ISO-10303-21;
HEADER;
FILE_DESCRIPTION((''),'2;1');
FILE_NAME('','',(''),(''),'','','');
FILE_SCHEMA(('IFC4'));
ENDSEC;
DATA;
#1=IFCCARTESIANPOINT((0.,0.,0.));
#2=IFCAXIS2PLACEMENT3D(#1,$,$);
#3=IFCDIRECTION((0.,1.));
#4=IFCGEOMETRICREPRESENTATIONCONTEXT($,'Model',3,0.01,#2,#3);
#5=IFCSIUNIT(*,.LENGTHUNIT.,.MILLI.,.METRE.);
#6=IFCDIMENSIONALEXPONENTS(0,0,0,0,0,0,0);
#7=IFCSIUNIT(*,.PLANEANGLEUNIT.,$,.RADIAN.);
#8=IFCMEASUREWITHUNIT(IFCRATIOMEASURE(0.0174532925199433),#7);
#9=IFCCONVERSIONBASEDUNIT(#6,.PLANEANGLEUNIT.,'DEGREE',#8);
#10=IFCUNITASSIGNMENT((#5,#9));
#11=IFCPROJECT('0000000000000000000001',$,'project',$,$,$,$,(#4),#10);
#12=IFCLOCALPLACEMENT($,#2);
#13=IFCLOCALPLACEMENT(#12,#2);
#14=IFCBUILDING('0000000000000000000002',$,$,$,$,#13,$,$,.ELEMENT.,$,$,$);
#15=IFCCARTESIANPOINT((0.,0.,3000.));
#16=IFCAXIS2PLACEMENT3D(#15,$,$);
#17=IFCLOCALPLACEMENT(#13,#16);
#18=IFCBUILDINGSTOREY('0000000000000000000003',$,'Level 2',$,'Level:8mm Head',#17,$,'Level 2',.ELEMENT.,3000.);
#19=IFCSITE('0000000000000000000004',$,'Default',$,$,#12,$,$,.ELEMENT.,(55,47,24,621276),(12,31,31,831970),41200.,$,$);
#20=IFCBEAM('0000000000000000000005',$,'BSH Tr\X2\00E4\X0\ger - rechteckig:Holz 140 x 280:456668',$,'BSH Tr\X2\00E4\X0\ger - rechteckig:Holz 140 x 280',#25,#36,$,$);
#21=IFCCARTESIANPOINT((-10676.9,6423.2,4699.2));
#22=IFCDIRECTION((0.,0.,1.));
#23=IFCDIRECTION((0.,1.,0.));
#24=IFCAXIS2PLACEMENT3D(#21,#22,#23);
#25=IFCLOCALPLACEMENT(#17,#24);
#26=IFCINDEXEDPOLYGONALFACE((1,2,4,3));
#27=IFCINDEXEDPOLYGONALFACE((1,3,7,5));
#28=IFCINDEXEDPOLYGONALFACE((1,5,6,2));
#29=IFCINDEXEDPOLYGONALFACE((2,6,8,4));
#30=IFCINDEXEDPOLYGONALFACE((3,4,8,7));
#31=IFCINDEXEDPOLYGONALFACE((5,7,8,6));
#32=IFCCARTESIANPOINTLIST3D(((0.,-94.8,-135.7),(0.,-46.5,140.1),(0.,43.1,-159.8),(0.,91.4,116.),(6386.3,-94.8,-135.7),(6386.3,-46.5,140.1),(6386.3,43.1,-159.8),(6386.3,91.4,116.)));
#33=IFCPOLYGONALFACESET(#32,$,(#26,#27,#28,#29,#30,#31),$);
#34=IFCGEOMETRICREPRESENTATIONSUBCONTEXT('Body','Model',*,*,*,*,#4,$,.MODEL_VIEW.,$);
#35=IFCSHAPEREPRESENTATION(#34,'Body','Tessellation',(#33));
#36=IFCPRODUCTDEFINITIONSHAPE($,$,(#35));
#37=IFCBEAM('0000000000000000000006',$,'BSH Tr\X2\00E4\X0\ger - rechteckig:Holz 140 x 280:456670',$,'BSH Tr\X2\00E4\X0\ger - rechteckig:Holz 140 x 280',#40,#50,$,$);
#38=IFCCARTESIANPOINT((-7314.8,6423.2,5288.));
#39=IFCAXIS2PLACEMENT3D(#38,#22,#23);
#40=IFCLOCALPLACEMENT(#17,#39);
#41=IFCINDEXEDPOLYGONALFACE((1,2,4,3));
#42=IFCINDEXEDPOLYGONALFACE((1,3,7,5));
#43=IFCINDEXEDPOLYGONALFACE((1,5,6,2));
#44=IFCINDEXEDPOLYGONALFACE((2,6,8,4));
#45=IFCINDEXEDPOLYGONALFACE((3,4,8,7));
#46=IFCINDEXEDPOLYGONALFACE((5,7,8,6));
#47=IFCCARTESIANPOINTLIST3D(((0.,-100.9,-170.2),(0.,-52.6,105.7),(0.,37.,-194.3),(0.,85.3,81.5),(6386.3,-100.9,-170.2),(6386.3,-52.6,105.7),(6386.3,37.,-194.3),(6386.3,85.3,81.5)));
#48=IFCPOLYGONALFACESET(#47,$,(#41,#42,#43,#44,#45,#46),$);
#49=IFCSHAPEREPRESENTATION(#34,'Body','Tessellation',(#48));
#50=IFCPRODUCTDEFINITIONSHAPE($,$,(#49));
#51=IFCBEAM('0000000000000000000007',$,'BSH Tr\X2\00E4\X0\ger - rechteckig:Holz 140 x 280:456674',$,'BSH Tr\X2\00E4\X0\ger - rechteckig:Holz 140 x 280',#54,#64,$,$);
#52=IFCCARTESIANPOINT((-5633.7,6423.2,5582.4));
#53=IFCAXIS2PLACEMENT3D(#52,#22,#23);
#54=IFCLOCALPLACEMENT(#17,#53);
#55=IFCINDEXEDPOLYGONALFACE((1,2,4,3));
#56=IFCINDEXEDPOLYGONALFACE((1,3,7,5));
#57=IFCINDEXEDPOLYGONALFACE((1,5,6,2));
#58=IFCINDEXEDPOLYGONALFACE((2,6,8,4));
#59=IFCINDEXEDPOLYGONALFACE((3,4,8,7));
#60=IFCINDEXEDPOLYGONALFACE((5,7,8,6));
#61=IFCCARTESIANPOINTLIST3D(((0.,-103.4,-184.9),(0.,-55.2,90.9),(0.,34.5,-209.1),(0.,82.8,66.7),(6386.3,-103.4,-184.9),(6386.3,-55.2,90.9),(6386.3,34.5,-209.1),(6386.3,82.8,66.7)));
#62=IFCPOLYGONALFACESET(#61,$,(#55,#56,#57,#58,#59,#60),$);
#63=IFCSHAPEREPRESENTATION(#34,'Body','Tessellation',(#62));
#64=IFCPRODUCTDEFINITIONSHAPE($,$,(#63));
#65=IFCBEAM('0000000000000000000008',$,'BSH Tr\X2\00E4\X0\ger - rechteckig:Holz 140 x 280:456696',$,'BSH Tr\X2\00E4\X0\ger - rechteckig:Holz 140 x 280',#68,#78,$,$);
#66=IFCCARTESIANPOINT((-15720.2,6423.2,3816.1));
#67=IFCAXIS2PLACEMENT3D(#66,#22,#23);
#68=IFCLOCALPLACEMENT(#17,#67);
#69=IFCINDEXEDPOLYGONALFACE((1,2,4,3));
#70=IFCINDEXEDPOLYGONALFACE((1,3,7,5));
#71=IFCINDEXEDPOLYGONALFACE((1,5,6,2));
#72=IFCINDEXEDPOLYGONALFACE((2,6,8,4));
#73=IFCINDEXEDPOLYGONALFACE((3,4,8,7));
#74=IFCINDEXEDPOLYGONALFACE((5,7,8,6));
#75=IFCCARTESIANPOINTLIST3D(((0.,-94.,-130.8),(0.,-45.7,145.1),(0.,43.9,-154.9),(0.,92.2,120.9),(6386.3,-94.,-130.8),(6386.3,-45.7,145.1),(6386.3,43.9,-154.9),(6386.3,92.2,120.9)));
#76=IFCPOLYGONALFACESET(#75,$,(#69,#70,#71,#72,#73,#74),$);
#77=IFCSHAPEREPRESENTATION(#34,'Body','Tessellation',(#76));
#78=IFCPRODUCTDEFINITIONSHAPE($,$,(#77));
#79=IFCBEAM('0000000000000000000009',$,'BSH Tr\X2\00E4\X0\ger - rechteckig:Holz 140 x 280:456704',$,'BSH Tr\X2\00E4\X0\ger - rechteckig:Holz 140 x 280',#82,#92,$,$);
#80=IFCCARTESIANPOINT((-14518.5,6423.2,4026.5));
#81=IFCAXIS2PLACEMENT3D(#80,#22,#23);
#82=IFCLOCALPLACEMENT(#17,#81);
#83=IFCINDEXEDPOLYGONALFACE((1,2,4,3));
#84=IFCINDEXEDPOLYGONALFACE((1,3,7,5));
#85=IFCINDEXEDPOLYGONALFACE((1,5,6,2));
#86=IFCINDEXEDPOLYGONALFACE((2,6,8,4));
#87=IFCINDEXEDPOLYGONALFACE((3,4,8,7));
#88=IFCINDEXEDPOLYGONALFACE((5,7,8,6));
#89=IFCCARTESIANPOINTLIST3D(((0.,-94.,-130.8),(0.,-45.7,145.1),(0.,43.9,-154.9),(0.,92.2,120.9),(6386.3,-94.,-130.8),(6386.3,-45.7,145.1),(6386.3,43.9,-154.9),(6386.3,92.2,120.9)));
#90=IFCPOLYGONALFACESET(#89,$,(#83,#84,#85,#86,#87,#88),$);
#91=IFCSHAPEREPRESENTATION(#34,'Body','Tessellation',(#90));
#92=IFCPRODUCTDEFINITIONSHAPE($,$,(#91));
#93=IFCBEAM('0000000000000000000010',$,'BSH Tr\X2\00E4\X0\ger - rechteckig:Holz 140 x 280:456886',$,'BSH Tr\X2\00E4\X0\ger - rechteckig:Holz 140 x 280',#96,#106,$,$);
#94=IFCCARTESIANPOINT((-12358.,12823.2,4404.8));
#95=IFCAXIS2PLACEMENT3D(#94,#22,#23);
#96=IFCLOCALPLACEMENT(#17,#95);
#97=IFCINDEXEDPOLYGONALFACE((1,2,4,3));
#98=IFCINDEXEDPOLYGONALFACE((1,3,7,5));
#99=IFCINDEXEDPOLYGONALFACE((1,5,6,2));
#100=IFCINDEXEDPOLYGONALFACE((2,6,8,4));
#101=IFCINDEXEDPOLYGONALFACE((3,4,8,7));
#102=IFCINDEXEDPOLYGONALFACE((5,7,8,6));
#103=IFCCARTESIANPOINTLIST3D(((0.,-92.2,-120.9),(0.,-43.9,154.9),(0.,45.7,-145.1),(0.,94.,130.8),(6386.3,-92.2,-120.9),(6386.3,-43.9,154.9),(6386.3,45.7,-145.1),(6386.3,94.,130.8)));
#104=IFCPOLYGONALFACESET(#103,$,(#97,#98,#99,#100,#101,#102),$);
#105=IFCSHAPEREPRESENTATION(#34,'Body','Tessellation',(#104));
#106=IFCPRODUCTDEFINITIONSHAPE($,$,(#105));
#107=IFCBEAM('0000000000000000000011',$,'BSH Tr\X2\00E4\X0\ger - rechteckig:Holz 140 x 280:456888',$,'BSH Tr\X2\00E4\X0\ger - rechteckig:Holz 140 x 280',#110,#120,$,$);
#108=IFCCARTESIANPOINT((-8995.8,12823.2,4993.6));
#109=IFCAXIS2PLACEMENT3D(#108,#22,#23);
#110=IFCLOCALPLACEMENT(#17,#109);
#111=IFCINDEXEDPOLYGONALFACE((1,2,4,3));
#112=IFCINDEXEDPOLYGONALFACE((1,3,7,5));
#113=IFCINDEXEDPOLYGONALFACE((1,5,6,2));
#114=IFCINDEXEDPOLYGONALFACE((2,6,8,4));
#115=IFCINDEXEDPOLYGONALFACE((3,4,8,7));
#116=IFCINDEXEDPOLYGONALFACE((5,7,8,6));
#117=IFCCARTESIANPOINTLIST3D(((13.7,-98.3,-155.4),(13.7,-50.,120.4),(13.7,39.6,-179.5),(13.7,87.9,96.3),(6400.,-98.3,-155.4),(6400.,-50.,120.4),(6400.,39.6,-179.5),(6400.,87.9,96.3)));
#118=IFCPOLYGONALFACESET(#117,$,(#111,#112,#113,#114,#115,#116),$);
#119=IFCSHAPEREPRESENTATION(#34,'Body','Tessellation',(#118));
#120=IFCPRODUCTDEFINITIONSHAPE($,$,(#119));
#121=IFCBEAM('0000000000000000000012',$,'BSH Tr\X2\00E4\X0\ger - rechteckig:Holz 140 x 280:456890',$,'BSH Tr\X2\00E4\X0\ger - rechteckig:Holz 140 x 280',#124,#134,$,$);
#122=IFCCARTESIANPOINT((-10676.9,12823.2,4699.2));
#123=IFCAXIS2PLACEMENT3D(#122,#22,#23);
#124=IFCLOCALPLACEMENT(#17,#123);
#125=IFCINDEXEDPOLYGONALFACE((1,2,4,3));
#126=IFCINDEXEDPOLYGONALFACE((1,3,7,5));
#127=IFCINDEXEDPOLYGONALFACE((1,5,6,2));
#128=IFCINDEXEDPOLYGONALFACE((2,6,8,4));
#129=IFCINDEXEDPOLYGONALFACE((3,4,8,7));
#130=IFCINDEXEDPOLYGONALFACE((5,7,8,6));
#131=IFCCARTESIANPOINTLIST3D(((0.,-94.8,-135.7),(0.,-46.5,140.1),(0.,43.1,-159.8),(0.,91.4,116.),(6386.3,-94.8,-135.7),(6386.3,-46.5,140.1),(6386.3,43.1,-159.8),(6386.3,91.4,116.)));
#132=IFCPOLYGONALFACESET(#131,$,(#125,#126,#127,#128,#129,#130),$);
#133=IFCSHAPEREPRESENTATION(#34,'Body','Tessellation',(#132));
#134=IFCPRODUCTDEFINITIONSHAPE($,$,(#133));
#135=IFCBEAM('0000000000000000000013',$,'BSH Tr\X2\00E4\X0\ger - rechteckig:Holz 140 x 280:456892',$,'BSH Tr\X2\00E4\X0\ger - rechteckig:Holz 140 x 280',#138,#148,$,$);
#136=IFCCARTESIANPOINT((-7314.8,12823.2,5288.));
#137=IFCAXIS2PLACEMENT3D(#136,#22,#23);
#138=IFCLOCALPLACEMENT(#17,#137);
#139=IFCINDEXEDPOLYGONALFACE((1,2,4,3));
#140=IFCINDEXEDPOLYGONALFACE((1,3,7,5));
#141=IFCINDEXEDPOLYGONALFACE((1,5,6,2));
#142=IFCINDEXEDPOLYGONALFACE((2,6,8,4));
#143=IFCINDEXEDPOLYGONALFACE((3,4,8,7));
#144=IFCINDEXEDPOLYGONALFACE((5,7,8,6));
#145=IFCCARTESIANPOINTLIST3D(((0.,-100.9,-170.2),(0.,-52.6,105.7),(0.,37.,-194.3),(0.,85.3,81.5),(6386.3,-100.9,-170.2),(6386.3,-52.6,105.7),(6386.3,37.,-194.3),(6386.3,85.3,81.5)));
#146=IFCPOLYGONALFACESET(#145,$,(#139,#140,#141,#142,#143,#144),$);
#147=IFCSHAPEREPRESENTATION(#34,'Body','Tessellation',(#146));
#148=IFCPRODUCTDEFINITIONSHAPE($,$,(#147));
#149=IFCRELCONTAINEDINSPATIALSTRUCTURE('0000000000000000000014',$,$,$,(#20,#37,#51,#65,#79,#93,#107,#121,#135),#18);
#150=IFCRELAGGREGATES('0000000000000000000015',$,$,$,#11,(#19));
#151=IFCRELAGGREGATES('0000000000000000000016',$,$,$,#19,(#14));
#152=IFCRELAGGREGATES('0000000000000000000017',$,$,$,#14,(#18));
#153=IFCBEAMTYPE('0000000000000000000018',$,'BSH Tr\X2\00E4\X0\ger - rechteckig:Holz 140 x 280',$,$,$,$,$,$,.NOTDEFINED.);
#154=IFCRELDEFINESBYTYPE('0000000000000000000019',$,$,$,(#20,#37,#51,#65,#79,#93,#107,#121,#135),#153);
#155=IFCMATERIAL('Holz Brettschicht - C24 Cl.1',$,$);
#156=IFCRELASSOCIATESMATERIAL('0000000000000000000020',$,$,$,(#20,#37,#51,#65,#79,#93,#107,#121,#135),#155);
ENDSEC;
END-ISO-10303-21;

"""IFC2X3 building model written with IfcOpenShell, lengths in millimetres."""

from ifc_helpers import new_model, entity, si_unit, converted_unit, direction, frame, frame_2d, origin, origin_2d_with_axis, place, context, subcontext, project, spatial, rectangle, extrude, material, type_object, element, save


model = new_model("IFC2X3")

# Units and contexts
model_context = context("Model", 3, precision=0.01, world=origin(), true_north=direction((0.0, 1.0)))
body_context = subcontext(model_context, "Body", "Model", "MODEL_VIEW")
ifc_project = project(units=[si_unit("LENGTHUNIT", "METRE", prefix="MILLI"), converted_unit("PLANEANGLEUNIT", "DEGREE", entity("IfcRatioMeasure", 0.0174532925199433), si_unit("PLANEANGLEUNIT", "RADIAN"), dimensions=[0, 0, 0, 0, 0, 0, 0])], contexts=[model_context])

# Site, building, storey
site_placement = place(None, origin())
site = spatial("IfcSite", under=ifc_project, at=site_placement, Name="Default", CompositionType="ELEMENT", RefLatitude=(55, 47, 24, 621276), RefLongitude=(12, 31, 31, 831970), RefElevation=41200.0)
building_placement = place(site_placement, origin())
building = spatial("IfcBuilding", under=site, at=building_placement, CompositionType="ELEMENT")
storey_placement = place(building_placement, frame((0.0, 0.0, 3000.0)))
storey = spatial("IfcBuildingStorey", under=building, at=storey_placement, Name="Level 2", ObjectType="Level:8mm Head", LongName="Level 2", CompositionType="ELEMENT", Elevation=3000.0)

# Shared definitions
ifc_material_1 = material(Name="Holz Brettschicht - C24 Cl.1")

# Beams
beam_type_1 = type_object("IfcBeamType", Name="BSH Träger - rechteckig:Holz 140 x 280", PredefinedType="NOTDEFINED")
beam_1_placement = place(storey_placement, frame((-10676.9, 6423.2, 4699.2), z_axis=(0.0, 0.0, 1.0), x_axis=(0.0, 1.0, 0.0)))
element("IfcBeam", 1, at=beam_1_placement, inside=storey, type_object=beam_type_1, material=ifc_material_1, Name="BSH Träger - rechteckig:Holz 140 x 280:456668", ObjectType="BSH Träger - rechteckig:Holz 140 x 280", context=body_context, shape_type="SweptSolid", body=[
    extrude(rectangle(XDim=280.0, YDim=140.0, at=origin_2d_with_axis()), frame((0.0, -1.7, -9.9), z_axis=(1.0, 0.0, 0.0), x_axis=(0.0, 0.172491, 0.985011)), (0.0, 0.0, 1.0), 6386.3),
])
beam_2_placement = place(storey_placement, frame((-7314.8, 6423.2, 5288.0), z_axis=(0.0, 0.0, 1.0), x_axis=(0.0, 1.0, 0.0)))
element("IfcBeam", 2, at=beam_2_placement, inside=storey, type_object=beam_type_1, material=ifc_material_1, Name="BSH Träger - rechteckig:Holz 140 x 280:456670", ObjectType="BSH Träger - rechteckig:Holz 140 x 280", context=body_context, shape_type="SweptSolid", body=[
    extrude(rectangle(XDim=280.0, YDim=140.0, at=origin_2d_with_axis()), frame((0.0, -7.8, -44.3), z_axis=(1.0, 0.0, 0.0), x_axis=(0.0, 0.172491, 0.985011)), (0.0, 0.0, 1.0), 6386.3),
])
beam_3_placement = place(storey_placement, frame((-5633.7, 6423.2, 5582.4), z_axis=(0.0, 0.0, 1.0), x_axis=(0.0, 1.0, 0.0)))
element("IfcBeam", 3, at=beam_3_placement, inside=storey, type_object=beam_type_1, material=ifc_material_1, Name="BSH Träger - rechteckig:Holz 140 x 280:456674", ObjectType="BSH Träger - rechteckig:Holz 140 x 280", context=body_context, shape_type="SweptSolid", body=[
    extrude(rectangle(XDim=280.0, YDim=140.0, at=origin_2d_with_axis()), frame((0.0, -10.3, -59.1), z_axis=(1.0, 0.0, 0.0), x_axis=(0.0, 0.172491, 0.985011)), (0.0, 0.0, 1.0), 6386.3),
])
beam_4_placement = place(storey_placement, frame((-15720.2, 6423.2, 3816.1), z_axis=(0.0, 0.0, 1.0), x_axis=(0.0, 1.0, 0.0)))
element("IfcBeam", 4, at=beam_4_placement, inside=storey, type_object=beam_type_1, material=ifc_material_1, Name="BSH Träger - rechteckig:Holz 140 x 280:456696", ObjectType="BSH Träger - rechteckig:Holz 140 x 280", context=body_context, shape_type="SweptSolid", body=[
    extrude(rectangle(XDim=280.0, YDim=140.0, at=origin_2d_with_axis()), frame((0.0, -0.9, -4.9), z_axis=(1.0, 0.0, 0.0), x_axis=(0.0, 0.172491, 0.985011)), (0.0, 0.0, 1.0), 6386.3),
])
beam_5_placement = place(storey_placement, frame((-14518.5, 6423.2, 4026.5), z_axis=(0.0, 0.0, 1.0), x_axis=(0.0, 1.0, 0.0)))
element("IfcBeam", 5, at=beam_5_placement, inside=storey, type_object=beam_type_1, material=ifc_material_1, Name="BSH Träger - rechteckig:Holz 140 x 280:456704", ObjectType="BSH Träger - rechteckig:Holz 140 x 280", context=body_context, shape_type="SweptSolid", body=[
    extrude(rectangle(XDim=280.0, YDim=140.0, at=frame_2d((0.0, 0.0), x_axis=(1.0, 0.0))), frame((0.0, -0.9, -4.9), z_axis=(1.0, 0.0, 0.0), x_axis=(0.0, 0.172491, 0.985011)), (0.0, 0.0, 1.0), 6386.3),
])
beam_6_placement = place(storey_placement, frame((-12358.0, 12823.2, 4404.8), z_axis=(0.0, 0.0, 1.0), x_axis=(0.0, 1.0, 0.0)))
element("IfcBeam", 6, at=beam_6_placement, inside=storey, type_object=beam_type_1, material=ifc_material_1, Name="BSH Träger - rechteckig:Holz 140 x 280:456886", ObjectType="BSH Träger - rechteckig:Holz 140 x 280", context=body_context, shape_type="SweptSolid", body=[
    extrude(rectangle(XDim=280.0, YDim=140.0, at=origin_2d_with_axis()), frame((0.0, 0.9, 4.9), z_axis=(1.0, 0.0, 0.0), x_axis=(0.0, 0.172491, 0.985011)), (0.0, 0.0, 1.0), 6386.3),
])
beam_7_placement = place(storey_placement, frame((-8995.8, 12823.2, 4993.6), z_axis=(0.0, 0.0, 1.0), x_axis=(0.0, 1.0, 0.0)))
element("IfcBeam", 7, at=beam_7_placement, inside=storey, type_object=beam_type_1, material=ifc_material_1, Name="BSH Träger - rechteckig:Holz 140 x 280:456888", ObjectType="BSH Träger - rechteckig:Holz 140 x 280", context=body_context, shape_type="SweptSolid", body=[
    extrude(rectangle(XDim=280.0, YDim=140.0, at=origin_2d_with_axis()), frame((13.7, -5.2, -29.6), z_axis=(1.0, 0.0, 0.0), x_axis=(0.0, 0.172491, 0.985011)), (0.0, 0.0, 1.0), 6386.3),
])
beam_8_placement = place(storey_placement, frame((-10676.9, 12823.2, 4699.2), z_axis=(0.0, 0.0, 1.0), x_axis=(0.0, 1.0, 0.0)))
element("IfcBeam", 8, at=beam_8_placement, inside=storey, type_object=beam_type_1, material=ifc_material_1, Name="BSH Träger - rechteckig:Holz 140 x 280:456890", ObjectType="BSH Träger - rechteckig:Holz 140 x 280", context=body_context, shape_type="SweptSolid", body=[
    extrude(rectangle(XDim=280.0, YDim=140.0, at=origin_2d_with_axis()), frame((0.0, -1.7, -9.9), z_axis=(1.0, 0.0, 0.0), x_axis=(0.0, 0.172491, 0.985011)), (0.0, 0.0, 1.0), 6386.3),
])
beam_9_placement = place(storey_placement, frame((-7314.8, 12823.2, 5288.0), z_axis=(0.0, 0.0, 1.0), x_axis=(0.0, 1.0, 0.0)))
element("IfcBeam", 9, at=beam_9_placement, inside=storey, type_object=beam_type_1, material=ifc_material_1, Name="BSH Träger - rechteckig:Holz 140 x 280:456892", ObjectType="BSH Träger - rechteckig:Holz 140 x 280", context=body_context, shape_type="SweptSolid", body=[
    extrude(rectangle(XDim=280.0, YDim=140.0, at=origin_2d_with_axis()), frame((0.0, -7.8, -44.3), z_axis=(1.0, 0.0, 0.0), x_axis=(0.0, 0.172491, 0.985011)), (0.0, 0.0, 1.0), 6386.3),
])

save(model, "model.ifc")
